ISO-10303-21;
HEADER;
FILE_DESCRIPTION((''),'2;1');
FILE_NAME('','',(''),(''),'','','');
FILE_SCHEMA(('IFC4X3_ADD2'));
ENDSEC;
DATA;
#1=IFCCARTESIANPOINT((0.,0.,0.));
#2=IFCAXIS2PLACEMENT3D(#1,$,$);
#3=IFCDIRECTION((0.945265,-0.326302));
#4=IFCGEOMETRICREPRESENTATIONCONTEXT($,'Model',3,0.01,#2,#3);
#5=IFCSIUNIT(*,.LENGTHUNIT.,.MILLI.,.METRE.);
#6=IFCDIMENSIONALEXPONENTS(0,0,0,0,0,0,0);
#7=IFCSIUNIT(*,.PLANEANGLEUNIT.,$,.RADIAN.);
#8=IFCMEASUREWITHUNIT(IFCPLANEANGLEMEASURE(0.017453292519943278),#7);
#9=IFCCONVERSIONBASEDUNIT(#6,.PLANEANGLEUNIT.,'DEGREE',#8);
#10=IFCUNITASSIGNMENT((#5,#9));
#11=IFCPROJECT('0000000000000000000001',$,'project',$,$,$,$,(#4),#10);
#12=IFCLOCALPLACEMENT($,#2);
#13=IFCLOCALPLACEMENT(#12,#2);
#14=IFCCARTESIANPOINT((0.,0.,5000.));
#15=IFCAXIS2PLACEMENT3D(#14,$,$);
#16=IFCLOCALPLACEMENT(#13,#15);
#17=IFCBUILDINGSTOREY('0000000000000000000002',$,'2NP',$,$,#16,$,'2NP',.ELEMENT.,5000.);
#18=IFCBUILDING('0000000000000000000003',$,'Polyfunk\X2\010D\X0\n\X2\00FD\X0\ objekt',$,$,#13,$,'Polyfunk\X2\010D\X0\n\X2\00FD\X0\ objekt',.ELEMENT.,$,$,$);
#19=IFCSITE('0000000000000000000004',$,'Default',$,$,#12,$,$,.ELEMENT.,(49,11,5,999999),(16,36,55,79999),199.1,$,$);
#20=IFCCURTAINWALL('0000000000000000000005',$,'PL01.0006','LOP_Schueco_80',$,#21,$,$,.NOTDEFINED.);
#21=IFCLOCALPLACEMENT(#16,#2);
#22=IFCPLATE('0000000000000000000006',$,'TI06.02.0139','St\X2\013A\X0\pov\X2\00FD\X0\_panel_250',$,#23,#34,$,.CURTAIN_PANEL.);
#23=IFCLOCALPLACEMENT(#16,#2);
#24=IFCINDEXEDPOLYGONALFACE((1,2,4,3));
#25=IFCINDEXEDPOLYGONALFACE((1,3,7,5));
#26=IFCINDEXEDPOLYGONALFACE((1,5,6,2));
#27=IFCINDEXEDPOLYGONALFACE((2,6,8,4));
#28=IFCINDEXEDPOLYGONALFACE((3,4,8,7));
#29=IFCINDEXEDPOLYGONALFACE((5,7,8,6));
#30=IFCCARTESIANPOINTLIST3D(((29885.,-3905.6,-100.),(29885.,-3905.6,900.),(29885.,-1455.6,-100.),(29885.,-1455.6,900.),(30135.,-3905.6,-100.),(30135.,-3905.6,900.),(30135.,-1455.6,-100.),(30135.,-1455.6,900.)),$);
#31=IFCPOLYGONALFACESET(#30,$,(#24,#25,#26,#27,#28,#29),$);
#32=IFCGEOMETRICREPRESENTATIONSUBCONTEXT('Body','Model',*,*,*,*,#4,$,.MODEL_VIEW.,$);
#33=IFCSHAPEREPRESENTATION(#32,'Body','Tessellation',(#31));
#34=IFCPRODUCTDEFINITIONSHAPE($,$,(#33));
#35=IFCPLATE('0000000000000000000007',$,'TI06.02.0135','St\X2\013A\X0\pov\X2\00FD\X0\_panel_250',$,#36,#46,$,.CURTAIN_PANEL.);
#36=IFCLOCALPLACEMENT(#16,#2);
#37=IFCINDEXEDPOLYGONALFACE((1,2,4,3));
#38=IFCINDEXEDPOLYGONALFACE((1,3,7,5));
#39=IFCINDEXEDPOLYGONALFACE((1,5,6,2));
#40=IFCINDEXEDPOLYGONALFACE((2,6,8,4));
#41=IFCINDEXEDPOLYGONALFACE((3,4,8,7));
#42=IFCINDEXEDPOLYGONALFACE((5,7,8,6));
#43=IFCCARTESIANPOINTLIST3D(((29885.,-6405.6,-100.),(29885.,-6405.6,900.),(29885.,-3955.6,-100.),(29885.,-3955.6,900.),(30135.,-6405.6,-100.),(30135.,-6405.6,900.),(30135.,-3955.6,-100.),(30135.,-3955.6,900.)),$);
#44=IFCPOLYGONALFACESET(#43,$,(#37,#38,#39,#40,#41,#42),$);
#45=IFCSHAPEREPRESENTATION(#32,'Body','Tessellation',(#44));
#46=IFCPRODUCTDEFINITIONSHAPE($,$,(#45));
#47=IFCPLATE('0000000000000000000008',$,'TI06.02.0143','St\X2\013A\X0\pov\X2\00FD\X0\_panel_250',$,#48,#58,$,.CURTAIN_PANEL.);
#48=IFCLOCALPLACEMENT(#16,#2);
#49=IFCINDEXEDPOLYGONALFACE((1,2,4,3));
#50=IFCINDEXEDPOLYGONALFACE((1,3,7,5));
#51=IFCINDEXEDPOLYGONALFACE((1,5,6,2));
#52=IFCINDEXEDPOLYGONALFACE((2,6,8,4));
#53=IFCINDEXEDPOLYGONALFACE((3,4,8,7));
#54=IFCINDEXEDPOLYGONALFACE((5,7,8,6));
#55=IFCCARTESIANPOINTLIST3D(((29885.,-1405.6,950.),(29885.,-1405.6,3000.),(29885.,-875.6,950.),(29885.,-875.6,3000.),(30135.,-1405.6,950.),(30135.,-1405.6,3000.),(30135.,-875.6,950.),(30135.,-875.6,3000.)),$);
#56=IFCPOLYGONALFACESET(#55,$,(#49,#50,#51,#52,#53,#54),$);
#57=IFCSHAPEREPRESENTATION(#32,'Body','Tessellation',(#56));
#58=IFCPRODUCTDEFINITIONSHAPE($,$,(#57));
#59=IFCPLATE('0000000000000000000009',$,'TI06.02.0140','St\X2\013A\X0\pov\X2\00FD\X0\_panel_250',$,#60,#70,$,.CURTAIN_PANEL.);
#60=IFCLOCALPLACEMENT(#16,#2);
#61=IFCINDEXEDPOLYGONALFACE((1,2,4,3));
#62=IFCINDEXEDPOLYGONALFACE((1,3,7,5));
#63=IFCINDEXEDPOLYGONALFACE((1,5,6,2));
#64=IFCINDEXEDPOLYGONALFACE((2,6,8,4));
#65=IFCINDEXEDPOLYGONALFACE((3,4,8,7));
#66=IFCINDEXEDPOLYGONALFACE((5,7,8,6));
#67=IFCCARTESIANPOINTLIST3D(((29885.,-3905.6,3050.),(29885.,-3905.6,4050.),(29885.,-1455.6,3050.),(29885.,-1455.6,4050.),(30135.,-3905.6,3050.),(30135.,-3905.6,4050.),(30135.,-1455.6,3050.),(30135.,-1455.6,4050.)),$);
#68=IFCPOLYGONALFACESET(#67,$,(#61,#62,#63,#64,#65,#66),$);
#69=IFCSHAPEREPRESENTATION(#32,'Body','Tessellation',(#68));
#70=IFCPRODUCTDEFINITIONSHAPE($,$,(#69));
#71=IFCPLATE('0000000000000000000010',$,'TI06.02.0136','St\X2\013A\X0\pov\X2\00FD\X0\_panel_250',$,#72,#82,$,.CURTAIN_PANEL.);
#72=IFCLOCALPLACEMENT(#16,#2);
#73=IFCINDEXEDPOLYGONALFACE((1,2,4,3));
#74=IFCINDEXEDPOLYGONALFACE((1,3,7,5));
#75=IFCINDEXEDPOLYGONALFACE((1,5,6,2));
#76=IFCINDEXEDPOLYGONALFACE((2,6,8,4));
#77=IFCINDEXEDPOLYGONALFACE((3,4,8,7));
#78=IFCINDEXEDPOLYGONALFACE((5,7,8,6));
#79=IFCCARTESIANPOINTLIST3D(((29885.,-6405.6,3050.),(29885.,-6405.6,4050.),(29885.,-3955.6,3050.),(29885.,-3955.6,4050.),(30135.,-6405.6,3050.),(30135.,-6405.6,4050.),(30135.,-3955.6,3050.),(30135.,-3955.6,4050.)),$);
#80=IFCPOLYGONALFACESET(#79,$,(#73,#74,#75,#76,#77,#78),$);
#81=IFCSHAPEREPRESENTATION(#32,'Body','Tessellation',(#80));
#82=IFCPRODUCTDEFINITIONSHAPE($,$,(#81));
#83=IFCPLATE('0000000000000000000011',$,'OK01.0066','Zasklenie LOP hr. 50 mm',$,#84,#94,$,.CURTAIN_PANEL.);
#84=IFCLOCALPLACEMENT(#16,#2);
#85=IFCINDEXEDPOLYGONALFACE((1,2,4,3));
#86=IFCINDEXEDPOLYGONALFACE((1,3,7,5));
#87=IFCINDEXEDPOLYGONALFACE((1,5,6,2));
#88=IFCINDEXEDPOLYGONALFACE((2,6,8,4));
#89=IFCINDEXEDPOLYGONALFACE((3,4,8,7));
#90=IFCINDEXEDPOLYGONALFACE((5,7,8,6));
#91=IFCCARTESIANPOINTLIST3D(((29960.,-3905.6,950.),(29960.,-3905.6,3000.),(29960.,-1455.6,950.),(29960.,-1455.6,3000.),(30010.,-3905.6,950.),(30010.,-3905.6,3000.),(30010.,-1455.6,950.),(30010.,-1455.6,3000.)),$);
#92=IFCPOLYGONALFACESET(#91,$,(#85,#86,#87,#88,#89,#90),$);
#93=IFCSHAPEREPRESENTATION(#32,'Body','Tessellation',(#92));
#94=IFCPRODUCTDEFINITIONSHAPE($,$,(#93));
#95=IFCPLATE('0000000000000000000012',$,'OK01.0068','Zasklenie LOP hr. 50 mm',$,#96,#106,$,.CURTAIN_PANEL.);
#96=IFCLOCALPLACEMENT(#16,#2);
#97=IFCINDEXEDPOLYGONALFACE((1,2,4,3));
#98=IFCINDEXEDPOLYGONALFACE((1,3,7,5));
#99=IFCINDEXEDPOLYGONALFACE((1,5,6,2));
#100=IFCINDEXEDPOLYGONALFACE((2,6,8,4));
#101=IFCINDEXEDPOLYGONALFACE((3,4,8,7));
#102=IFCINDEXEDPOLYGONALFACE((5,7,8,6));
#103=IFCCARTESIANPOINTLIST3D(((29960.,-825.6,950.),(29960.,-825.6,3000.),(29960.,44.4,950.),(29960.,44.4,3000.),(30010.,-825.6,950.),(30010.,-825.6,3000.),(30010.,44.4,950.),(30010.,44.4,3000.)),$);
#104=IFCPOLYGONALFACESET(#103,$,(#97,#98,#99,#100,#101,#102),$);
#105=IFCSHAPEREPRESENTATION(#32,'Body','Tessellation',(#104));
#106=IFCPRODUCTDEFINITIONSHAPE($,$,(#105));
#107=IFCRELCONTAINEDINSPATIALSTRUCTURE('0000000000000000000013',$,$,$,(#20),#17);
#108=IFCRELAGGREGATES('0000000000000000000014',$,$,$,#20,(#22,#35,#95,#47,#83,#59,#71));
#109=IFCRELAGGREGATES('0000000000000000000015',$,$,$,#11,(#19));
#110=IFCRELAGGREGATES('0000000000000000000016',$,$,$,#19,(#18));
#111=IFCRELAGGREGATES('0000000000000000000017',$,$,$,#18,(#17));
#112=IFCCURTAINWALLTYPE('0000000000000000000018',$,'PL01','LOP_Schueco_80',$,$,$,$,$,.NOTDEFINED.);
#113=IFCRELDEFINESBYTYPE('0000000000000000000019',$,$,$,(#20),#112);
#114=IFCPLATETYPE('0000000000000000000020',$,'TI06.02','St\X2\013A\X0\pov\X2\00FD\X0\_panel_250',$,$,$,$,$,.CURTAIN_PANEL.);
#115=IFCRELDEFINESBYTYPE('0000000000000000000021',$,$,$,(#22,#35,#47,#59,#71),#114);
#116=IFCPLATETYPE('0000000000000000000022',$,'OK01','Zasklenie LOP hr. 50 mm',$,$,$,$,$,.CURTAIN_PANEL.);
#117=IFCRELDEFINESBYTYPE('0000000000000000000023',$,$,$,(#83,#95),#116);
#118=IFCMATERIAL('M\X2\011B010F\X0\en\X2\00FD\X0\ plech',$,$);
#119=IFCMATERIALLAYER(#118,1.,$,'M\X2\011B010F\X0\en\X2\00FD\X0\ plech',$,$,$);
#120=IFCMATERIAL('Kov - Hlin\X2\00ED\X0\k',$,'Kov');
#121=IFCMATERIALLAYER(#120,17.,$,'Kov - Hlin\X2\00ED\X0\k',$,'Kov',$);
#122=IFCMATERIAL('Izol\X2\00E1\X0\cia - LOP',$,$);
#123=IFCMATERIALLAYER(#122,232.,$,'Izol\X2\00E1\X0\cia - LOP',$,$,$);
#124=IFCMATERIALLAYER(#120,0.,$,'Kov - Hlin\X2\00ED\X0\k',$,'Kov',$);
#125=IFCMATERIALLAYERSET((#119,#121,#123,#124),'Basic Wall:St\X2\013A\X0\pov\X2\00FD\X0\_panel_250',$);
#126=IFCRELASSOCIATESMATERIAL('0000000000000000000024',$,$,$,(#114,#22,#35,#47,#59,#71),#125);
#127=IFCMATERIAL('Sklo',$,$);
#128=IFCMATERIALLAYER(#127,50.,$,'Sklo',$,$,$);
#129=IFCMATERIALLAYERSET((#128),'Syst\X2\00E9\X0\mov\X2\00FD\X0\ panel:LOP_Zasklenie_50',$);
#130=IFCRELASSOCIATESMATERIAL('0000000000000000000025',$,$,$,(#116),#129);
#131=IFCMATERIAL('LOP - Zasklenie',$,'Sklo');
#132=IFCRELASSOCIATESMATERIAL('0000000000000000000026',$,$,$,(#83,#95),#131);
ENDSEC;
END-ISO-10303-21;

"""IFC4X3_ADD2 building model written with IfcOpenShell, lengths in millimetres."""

from ifc_helpers import new_model, entity, si_unit, converted_unit, direction, frame, frame_2d, origin, origin_2d_with_axis, place, context, subcontext, project, spatial, rectangle, extrude, source, transform, mapped, material, layer, layer_set, layer_usage, type_object, type_shapes, element, aggregate, save


model = new_model("IFC4X3_ADD2")

# Units and contexts
model_context = context("Model", 3, precision=0.01, world=origin(), true_north=direction((0.945265, -0.326302)))
body_context = subcontext(model_context, "Body", "Model", "MODEL_VIEW")
ifc_project = project(units=[si_unit("LENGTHUNIT", "METRE", prefix="MILLI"), converted_unit("PLANEANGLEUNIT", "DEGREE", entity("IfcPlaneAngleMeasure", 0.017453292519943278), si_unit("PLANEANGLEUNIT", "RADIAN"), dimensions=[0, 0, 0, 0, 0, 0, 0])], contexts=[model_context])

# Site, building, storey
site_placement = place(None, origin())
site = spatial("IfcSite", under=ifc_project, at=site_placement, Name="Default", CompositionType="ELEMENT", RefLatitude=(49, 11, 5, 999999), RefLongitude=(16, 36, 55, 79999), RefElevation=199.1)
building_placement = place(site_placement, origin())
building = spatial("IfcBuilding", under=site, at=building_placement, Name="Polyfunkčný objekt", LongName="Polyfunkčný objekt", CompositionType="ELEMENT")
storey_placement = place(building_placement, frame((0.0, 0.0, 5000.0)))
storey = spatial("IfcBuildingStorey", under=building, at=storey_placement, Name="2NP", LongName="2NP", CompositionType="ELEMENT", Elevation=5000.0)

# Curtain wall, plates
curtain_wall_type = type_object("IfcCurtainWallType", Name="PL01", Description="LOP_Schueco_80", PredefinedType="NOTDEFINED")
curtain_wall_placement = place(storey_placement, frame((0.0, 0.0, -5000.0)))
curtain_wall = element("IfcCurtainWall", 1, at=curtain_wall_placement, inside=storey, type_object=curtain_wall_type, Name="PL01.0006", Description="LOP_Schueco_80", PredefinedType="NOTDEFINED")
ifc_material_1 = material(Name="Měďený plech")
ifc_layer_1 = layer(ifc_material_1, 1.0, Name="Měďený plech")
ifc_material_2 = material(Name="Kov - Hliník", Category="Kov")
ifc_layer_2 = layer(ifc_material_2, 17.0, Name="Kov - Hliník", Category="Kov")
ifc_material_3 = material(Name="Izolácia - LOP")
ifc_layer_3 = layer(ifc_material_3, 232.0, Name="Izolácia - LOP")
ifc_layer_4 = layer(ifc_material_2, 0.0, Name="Kov - Hliník", Category="Kov")
ifc_layer_set_1 = layer_set([ifc_layer_1, ifc_layer_2, ifc_layer_3, ifc_layer_4], Name="Basic Wall:Stĺpový_panel_250")
ifc_layer_usage_1 = layer_usage(ifc_layer_set_1, "AXIS2", "POSITIVE", -125.0)
plate_type_1 = type_object("IfcPlateType", Name="TI06.02", Description="Stĺpový_panel_250", PredefinedType="CURTAIN_PANEL", material=ifc_layer_set_1)
plate_1_placement = place(storey_placement, frame((30010.0, -1455.6, -100.0), z_axis=(0.0, 0.0, 1.0), x_axis=(0.0, -1.0, 0.0)))
plate_1 = element("IfcPlate", 2, at=plate_1_placement, type_object=plate_type_1, material=ifc_layer_usage_1, Name="TI06.02.0139", Description="Stĺpový_panel_250", PredefinedType="CURTAIN_PANEL", context=body_context, shape_type="SweptSolid", body=[
    extrude(rectangle(XDim=250.0, YDim=2450.0, at=origin_2d_with_axis()), frame((1225.0, 0.0, 0.0), z_axis=(0.0, 0.0, 1.0), x_axis=(0.0, 1.0, 0.0)), (0.0, 0.0, 1.0), 1000.0),
])
ifc_layer_usage_2 = layer_usage(ifc_layer_set_1, "AXIS2", "POSITIVE", -125.0)
plate_2_placement = place(storey_placement, frame((30010.0, -3955.6, -100.0), z_axis=(0.0, 0.0, 1.0), x_axis=(0.0, -1.0, 0.0)))
plate_2 = element("IfcPlate", 3, at=plate_2_placement, type_object=plate_type_1, material=ifc_layer_usage_2, Name="TI06.02.0135", Description="Stĺpový_panel_250", PredefinedType="CURTAIN_PANEL", context=body_context, shape_type="SweptSolid", body=[
    extrude(rectangle(XDim=250.0, YDim=2450.0, at=frame_2d((0.0, 0.0), x_axis=(1.0, 0.0))), frame((1225.0, 0.0, 0.0), z_axis=(0.0, 0.0, 1.0), x_axis=(0.0, 1.0, 0.0)), (0.0, 0.0, 1.0), 1000.0),
])
ifc_layer_usage_3 = layer_usage(ifc_layer_set_1, "AXIS2", "POSITIVE", -125.0)
plate_3_placement = place(storey_placement, frame((30010.0, -875.6, 950.0), z_axis=(0.0, 0.0, 1.0), x_axis=(0.0, -1.0, 0.0)))
plate_3 = element("IfcPlate", 4, at=plate_3_placement, type_object=plate_type_1, material=ifc_layer_usage_3, Name="TI06.02.0143", Description="Stĺpový_panel_250", PredefinedType="CURTAIN_PANEL", context=body_context, shape_type="SweptSolid", body=[
    extrude(rectangle(XDim=250.0, YDim=530.0, at=frame_2d((0.0, 0.0), x_axis=(1.0, 0.0))), frame((265.0, 0.0, 0.0), z_axis=(0.0, 0.0, 1.0), x_axis=(0.0, 1.0, 0.0)), (0.0, 0.0, 1.0), 2050.0),
])
ifc_layer_usage_4 = layer_usage(ifc_layer_set_1, "AXIS2", "POSITIVE", -125.0)
plate_4_placement = place(storey_placement, frame((30010.0, -1455.6, 3050.0), z_axis=(0.0, 0.0, 1.0), x_axis=(0.0, -1.0, 0.0)))
plate_4 = element("IfcPlate", 5, at=plate_4_placement, type_object=plate_type_1, material=ifc_layer_usage_4, Name="TI06.02.0140", Description="Stĺpový_panel_250", PredefinedType="CURTAIN_PANEL", context=body_context, shape_type="SweptSolid", body=[
    extrude(rectangle(XDim=250.0, YDim=2450.0, at=origin_2d_with_axis()), frame((1225.0, 0.0, 0.0), z_axis=(0.0, 0.0, 1.0), x_axis=(0.0, 1.0, 0.0)), (0.0, 0.0, 1.0), 1000.0),
])
ifc_layer_usage_5 = layer_usage(ifc_layer_set_1, "AXIS2", "POSITIVE", -125.0)
plate_5_placement = place(storey_placement, frame((30010.0, -3955.6, 3050.0), z_axis=(0.0, 0.0, 1.0), x_axis=(0.0, -1.0, 0.0)))
plate_5 = element("IfcPlate", 6, at=plate_5_placement, type_object=plate_type_1, material=ifc_layer_usage_5, Name="TI06.02.0136", Description="Stĺpový_panel_250", PredefinedType="CURTAIN_PANEL", context=body_context, shape_type="SweptSolid", body=[
    extrude(rectangle(XDim=250.0, YDim=2450.0, at=frame_2d((0.0, 0.0), x_axis=(1.0, 0.0))), frame((1225.0, 0.0, 0.0), z_axis=(0.0, 0.0, 1.0), x_axis=(0.0, 1.0, 0.0)), (0.0, 0.0, 1.0), 1000.0),
])
ifc_material_4 = material(Name="LOP - Zasklenie", Category="Sklo")
ifc_material_5 = material(Name="Sklo")
ifc_layer_5 = layer(ifc_material_5, 50.0, Name="Sklo")
ifc_layer_set_2 = layer_set([ifc_layer_5], Name="Systémový panel:LOP_Zasklenie_50")
plate_type_2 = type_object("IfcPlateType", Name="OK01", Description="Zasklenie LOP hr. 50 mm", PredefinedType="CURTAIN_PANEL", material=ifc_layer_set_2)
shared_shape_1 = source(origin(), body_context, "Body", "SweptSolid", [
    extrude(rectangle(XDim=50.0, YDim=2450.0, at=origin_2d_with_axis()), frame((0.0, -25.0, 0.0), z_axis=(0.0, 0.0, 1.0), x_axis=(0.0, 1.0, 0.0)), (0.0, 0.0, 1.0), 2050.0),
])
plate_6_placement = place(curtain_wall_placement, frame((30010.0, -2680.6, 5950.0), z_axis=(0.0, 0.0, 1.0), x_axis=(0.0, -1.0, 0.0)))
plate_6 = element("IfcPlate", 7, at=plate_6_placement, type_object=plate_type_2, material=ifc_material_4, Name="OK01.0066", Description="Zasklenie LOP hr. 50 mm", PredefinedType="CURTAIN_PANEL", context=body_context, shape_type="MappedRepresentation", body=[
    mapped(shared_shape_1, transform((0.0, 0.0, 0.0), scale=1.0)),
])
shared_shape_2 = source(origin(), body_context, "Body", "SweptSolid", [
    extrude(rectangle(XDim=50.0, YDim=870.0, at=origin_2d_with_axis()), frame((0.0, -25.0, 0.0), z_axis=(0.0, 0.0, 1.0), x_axis=(0.0, 1.0, 0.0)), (0.0, 0.0, 1.0), 2050.0),
])
type_shapes(plate_type_2, [shared_shape_1, shared_shape_2])
plate_7_placement = place(curtain_wall_placement, frame((30010.0, -390.6, 5950.0), z_axis=(0.0, 0.0, 1.0), x_axis=(0.0, -1.0, 0.0)))
plate_7 = element("IfcPlate", 8, at=plate_7_placement, type_object=plate_type_2, material=ifc_material_4, Name="OK01.0068", Description="Zasklenie LOP hr. 50 mm", PredefinedType="CURTAIN_PANEL", context=body_context, shape_type="MappedRepresentation", body=[
    mapped(shared_shape_2, transform((0.0, 0.0, 0.0), scale=1.0)),
])
aggregate(curtain_wall, [plate_1, plate_2, plate_7, plate_3, plate_6, plate_4, plate_5])

save(model, "model.ifc")
